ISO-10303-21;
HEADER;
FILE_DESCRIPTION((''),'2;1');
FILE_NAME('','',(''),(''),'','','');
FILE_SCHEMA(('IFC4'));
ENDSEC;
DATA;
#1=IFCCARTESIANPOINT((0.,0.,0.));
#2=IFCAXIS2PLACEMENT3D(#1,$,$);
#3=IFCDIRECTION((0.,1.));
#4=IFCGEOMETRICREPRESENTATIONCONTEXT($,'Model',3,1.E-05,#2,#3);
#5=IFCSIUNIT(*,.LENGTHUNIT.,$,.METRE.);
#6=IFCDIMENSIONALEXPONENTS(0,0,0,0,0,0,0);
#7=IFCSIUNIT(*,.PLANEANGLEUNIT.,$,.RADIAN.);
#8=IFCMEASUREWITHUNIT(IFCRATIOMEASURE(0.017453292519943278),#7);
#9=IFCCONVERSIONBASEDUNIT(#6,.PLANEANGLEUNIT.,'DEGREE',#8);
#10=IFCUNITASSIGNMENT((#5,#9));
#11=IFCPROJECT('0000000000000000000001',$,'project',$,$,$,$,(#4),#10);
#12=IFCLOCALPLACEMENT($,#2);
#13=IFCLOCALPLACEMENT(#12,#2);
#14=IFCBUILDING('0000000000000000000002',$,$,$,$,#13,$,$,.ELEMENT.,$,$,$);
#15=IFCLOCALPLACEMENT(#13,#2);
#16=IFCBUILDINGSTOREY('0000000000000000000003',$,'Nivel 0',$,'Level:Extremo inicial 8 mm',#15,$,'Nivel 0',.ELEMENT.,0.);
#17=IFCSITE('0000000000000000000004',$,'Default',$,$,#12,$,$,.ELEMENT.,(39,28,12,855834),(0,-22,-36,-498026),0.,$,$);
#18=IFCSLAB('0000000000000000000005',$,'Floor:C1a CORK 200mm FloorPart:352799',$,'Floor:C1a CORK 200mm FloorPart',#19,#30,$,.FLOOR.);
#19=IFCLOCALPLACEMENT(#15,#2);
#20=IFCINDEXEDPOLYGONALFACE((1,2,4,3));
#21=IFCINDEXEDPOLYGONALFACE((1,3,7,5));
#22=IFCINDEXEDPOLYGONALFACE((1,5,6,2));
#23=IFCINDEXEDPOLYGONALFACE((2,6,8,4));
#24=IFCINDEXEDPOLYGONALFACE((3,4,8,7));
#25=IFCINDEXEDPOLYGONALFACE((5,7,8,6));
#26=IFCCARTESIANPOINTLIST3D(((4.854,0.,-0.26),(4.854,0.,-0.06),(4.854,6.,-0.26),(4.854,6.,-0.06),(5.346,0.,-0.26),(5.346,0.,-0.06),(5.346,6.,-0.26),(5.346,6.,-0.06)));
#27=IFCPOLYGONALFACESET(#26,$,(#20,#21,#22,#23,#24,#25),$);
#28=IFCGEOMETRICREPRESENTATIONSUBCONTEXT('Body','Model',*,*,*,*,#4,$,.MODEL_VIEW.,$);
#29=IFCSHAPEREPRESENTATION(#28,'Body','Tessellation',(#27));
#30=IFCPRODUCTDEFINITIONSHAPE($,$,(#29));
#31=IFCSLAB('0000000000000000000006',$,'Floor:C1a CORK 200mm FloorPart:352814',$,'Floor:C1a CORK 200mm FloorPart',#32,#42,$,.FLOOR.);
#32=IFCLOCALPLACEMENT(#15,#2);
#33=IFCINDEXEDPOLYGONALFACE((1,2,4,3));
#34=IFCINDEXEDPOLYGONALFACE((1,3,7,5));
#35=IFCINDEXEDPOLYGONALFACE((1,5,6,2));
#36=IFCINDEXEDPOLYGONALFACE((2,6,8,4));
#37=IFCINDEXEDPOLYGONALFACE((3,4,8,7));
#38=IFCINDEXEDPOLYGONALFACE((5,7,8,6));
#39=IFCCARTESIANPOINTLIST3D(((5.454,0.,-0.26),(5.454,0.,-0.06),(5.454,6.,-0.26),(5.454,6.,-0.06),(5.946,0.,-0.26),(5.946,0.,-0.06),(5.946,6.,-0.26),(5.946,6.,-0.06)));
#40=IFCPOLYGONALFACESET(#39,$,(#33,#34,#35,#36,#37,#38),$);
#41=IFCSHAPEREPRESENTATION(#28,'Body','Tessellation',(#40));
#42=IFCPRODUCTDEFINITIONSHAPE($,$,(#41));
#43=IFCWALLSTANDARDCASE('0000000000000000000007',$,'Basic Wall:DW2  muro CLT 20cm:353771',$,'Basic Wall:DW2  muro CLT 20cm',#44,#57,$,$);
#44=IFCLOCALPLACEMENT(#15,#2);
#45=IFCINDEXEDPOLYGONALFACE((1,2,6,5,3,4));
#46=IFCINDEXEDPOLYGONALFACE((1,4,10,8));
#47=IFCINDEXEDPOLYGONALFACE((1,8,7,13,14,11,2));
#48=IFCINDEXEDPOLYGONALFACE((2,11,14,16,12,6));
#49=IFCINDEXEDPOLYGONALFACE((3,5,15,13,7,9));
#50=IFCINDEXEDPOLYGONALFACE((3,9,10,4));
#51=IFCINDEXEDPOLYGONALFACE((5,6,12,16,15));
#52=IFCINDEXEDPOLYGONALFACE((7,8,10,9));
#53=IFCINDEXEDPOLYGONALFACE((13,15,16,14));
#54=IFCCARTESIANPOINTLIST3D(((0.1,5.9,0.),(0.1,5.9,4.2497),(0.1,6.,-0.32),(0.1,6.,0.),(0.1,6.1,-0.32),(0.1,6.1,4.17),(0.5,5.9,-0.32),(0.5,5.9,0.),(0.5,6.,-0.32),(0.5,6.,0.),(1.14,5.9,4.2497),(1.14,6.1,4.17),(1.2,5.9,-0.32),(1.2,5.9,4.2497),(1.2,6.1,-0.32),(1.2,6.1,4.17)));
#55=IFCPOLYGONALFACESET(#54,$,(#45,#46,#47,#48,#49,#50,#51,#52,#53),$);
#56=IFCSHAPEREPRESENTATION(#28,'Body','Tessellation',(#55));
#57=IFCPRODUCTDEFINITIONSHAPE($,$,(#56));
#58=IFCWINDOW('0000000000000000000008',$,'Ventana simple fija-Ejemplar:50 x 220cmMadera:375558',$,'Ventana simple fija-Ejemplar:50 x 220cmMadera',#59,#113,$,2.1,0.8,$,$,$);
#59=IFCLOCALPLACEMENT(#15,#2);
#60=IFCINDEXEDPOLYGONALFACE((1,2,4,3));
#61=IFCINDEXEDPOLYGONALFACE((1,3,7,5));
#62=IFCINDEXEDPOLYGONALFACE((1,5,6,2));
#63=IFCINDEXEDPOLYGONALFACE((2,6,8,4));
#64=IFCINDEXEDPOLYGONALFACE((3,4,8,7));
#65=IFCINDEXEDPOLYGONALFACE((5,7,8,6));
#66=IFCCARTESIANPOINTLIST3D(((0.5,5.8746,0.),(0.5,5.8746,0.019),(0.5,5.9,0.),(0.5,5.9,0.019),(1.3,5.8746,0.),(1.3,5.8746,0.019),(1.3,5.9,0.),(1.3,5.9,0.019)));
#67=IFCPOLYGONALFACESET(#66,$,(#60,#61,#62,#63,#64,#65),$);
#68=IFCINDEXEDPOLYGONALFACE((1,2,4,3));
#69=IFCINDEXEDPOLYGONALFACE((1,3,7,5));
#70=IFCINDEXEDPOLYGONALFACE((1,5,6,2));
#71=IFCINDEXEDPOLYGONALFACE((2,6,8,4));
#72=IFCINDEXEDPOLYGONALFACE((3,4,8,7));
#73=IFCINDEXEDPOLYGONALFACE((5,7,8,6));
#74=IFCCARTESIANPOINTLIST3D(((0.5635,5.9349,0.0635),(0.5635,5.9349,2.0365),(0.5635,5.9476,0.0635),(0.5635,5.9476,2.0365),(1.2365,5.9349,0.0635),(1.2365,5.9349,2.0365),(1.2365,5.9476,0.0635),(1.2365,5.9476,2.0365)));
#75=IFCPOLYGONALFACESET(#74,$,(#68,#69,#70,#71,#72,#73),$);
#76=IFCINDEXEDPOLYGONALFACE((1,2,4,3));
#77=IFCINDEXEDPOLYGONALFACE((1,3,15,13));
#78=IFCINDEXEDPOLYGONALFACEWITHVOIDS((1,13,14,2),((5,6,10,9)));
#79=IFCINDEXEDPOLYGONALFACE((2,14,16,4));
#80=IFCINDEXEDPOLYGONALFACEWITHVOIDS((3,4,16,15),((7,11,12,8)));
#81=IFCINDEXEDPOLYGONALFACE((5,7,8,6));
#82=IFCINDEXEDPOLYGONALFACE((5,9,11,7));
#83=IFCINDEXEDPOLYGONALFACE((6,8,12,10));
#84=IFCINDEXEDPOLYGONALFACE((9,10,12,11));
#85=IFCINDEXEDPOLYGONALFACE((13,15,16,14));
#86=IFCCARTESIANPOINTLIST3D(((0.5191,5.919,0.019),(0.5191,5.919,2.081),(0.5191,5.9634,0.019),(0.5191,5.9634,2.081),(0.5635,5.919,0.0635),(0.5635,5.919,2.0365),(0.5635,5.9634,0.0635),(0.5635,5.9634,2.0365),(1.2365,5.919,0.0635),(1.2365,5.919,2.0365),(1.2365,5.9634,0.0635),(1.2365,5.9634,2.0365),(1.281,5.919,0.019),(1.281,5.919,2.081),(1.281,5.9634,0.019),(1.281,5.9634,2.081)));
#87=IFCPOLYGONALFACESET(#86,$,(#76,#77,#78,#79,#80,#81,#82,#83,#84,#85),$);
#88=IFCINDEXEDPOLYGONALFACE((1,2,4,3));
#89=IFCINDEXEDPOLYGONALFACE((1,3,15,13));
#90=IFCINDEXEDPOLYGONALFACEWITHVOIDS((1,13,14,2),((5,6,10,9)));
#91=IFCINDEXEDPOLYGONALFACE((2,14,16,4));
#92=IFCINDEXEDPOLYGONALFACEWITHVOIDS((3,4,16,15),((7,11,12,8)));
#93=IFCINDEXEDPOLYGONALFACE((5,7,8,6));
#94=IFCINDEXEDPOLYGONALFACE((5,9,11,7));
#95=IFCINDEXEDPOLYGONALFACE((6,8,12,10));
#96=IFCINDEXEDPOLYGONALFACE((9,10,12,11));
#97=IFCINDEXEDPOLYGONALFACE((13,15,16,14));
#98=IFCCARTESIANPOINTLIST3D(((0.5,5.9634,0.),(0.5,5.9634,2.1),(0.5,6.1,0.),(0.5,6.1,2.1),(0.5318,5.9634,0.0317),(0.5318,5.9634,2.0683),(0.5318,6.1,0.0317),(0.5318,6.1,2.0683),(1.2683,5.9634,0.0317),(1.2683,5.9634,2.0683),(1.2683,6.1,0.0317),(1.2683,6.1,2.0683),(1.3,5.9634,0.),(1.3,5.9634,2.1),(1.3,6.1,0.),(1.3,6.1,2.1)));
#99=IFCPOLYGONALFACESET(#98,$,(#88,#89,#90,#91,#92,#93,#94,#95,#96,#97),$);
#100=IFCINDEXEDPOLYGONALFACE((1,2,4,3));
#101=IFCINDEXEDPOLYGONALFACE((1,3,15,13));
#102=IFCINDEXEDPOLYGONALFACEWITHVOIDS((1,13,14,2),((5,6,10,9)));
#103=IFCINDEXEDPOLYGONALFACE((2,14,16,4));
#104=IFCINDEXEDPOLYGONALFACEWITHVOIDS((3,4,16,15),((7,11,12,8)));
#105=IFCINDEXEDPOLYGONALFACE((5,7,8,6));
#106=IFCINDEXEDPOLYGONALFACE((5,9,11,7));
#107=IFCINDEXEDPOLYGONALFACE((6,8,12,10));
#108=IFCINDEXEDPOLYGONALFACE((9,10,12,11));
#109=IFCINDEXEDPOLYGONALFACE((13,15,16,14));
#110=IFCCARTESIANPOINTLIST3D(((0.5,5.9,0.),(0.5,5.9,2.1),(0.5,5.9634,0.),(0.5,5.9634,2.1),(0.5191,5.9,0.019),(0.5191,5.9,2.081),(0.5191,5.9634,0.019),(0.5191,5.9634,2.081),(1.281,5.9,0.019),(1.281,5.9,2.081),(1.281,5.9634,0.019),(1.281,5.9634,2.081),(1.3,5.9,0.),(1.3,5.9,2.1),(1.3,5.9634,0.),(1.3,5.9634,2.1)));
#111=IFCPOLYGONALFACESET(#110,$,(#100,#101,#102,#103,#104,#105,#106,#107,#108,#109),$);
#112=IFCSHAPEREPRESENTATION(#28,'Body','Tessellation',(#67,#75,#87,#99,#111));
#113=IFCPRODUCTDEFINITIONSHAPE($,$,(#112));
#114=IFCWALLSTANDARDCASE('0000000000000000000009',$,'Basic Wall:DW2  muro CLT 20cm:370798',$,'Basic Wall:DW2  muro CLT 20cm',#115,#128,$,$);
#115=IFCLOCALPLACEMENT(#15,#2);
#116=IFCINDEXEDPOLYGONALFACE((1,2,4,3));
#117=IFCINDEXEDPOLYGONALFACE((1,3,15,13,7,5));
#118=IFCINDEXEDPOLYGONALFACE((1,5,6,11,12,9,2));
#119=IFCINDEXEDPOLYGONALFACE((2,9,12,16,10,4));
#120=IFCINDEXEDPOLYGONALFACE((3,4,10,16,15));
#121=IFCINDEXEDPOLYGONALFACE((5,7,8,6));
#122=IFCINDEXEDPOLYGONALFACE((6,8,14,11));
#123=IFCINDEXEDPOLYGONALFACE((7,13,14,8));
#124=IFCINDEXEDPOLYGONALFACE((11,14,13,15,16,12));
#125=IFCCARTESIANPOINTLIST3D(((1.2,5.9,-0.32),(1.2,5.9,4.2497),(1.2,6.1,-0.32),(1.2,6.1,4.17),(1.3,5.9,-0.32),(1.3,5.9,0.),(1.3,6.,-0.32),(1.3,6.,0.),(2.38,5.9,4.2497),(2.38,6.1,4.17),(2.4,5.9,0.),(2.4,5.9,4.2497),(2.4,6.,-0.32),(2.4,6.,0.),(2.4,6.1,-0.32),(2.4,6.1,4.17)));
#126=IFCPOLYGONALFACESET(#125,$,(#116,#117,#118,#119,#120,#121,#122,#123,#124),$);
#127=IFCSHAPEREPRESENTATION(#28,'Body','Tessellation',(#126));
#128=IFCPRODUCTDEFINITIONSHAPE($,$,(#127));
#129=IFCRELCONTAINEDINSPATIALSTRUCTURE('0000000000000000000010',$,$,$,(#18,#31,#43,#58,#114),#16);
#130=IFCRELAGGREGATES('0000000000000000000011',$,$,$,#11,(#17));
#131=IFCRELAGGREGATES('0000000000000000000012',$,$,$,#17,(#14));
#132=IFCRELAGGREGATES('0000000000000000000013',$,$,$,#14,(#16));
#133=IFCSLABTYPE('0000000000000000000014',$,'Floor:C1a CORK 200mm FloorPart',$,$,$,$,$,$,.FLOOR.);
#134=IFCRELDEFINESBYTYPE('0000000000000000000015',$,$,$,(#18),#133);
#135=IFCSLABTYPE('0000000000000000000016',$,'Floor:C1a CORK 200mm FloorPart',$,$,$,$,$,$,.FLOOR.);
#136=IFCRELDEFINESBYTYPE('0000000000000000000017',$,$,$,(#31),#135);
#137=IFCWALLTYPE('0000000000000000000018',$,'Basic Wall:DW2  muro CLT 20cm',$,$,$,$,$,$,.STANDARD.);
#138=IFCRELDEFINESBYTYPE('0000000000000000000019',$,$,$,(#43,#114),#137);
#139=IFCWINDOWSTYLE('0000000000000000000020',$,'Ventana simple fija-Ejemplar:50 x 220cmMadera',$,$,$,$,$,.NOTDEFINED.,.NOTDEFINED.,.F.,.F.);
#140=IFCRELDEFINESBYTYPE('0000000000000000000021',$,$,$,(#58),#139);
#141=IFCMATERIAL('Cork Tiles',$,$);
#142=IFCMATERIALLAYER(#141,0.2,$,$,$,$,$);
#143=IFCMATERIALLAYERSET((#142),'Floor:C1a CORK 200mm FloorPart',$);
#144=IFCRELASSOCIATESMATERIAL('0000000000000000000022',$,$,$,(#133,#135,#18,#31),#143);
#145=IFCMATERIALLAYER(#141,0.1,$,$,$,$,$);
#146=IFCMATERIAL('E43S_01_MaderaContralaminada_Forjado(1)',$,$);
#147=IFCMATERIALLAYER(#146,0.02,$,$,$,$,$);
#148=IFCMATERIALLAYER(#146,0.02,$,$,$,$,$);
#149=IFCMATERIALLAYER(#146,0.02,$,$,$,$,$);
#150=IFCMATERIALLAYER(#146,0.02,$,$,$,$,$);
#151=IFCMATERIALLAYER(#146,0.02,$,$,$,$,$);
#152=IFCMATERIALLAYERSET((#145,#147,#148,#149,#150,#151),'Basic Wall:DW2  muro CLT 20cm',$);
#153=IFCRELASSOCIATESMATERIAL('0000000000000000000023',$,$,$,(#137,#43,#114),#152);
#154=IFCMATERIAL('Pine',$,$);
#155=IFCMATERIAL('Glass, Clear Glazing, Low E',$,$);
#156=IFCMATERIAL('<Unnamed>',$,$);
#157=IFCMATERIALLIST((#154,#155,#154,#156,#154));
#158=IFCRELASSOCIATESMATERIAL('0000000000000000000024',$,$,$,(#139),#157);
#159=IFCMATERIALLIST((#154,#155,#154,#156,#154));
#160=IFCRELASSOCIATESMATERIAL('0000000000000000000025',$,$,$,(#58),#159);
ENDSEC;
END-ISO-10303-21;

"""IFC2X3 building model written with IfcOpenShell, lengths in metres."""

from ifc_helpers import new_model, entity, si_unit, converted_unit, direction, frame, frame_2d, origin, origin_2d_with_axis, place, context, subcontext, project, spatial, polyline, rectangle, outline, extrude, clip, bounded_halfspace, source, transform, mapped, material, material_list, layer, layer_set, layer_usage, type_object, type_shapes, element, fill, save


model = new_model("IFC2X3")

# Units and contexts
model_context = context("Model", 3, precision=1e-05, world=origin(), true_north=direction((0.0, 1.0)))
body_context = subcontext(model_context, "Body", "Model", "MODEL_VIEW")
ifc_project = project(units=[si_unit("LENGTHUNIT", "METRE"), converted_unit("PLANEANGLEUNIT", "DEGREE", entity("IfcRatioMeasure", 0.017453292519943278), si_unit("PLANEANGLEUNIT", "RADIAN"), dimensions=[0, 0, 0, 0, 0, 0, 0])], contexts=[model_context])

# Site, building, storey
site_placement = place(None, origin())
site = spatial("IfcSite", under=ifc_project, at=site_placement, Name="Default", CompositionType="ELEMENT", RefLatitude=(39, 28, 12, 855834), RefLongitude=(0, -22, -36, -498026), RefElevation=0.0)
building_placement = place(site_placement, origin())
building = spatial("IfcBuilding", under=site, at=building_placement, CompositionType="ELEMENT")
storey_placement = place(building_placement, origin())
storey = spatial("IfcBuildingStorey", under=building, at=storey_placement, Name="Nivel 0", ObjectType="Level:Extremo inicial 8 mm", LongName="Nivel 0", CompositionType="ELEMENT", Elevation=0.0)

# Shared definitions
ifc_material_1 = material(Name="E43S_01_MaderaContralaminada_Forjado(1)")

# Slabs
ifc_material_2 = material(Name="Cork Tiles")
ifc_layer_1 = layer(ifc_material_2, 0.2)
ifc_layer_set_1 = layer_set([ifc_layer_1], Name="Floor:C1a CORK 200mm FloorPart")
ifc_layer_usage_1 = layer_usage(ifc_layer_set_1, "AXIS3", "POSITIVE", 0.0)
slab_type_1 = type_object("IfcSlabType", Name="Floor:C1a CORK 200mm FloorPart", PredefinedType="FLOOR", material=ifc_layer_set_1)
slab_1_placement = place(storey_placement, origin())
element("IfcSlab", 1, at=slab_1_placement, inside=storey, type_object=slab_type_1, material=ifc_layer_usage_1, Name="Floor:C1a CORK 200mm FloorPart:352799", ObjectType="Floor:C1a CORK 200mm FloorPart", PredefinedType="FLOOR", context=body_context, shape_type="SweptSolid", body=[
    extrude(rectangle(XDim=6.0, YDim=0.492, at=frame_2d((0.0, 0.0), x_axis=(1.0, 0.0))), frame((5.1, 3.0, -0.06), z_axis=(0.0, 0.0, -1.0), x_axis=(0.0, 1.0, 0.0)), (0.0, 0.0, 1.0), 0.2),
])
ifc_layer_usage_2 = layer_usage(ifc_layer_set_1, "AXIS3", "POSITIVE", 0.0)
slab_type_2 = type_object("IfcSlabType", Name="Floor:C1a CORK 200mm FloorPart", PredefinedType="FLOOR", material=ifc_layer_set_1)
slab_2_placement = place(storey_placement, origin())
element("IfcSlab", 2, at=slab_2_placement, inside=storey, type_object=slab_type_2, material=ifc_layer_usage_2, Name="Floor:C1a CORK 200mm FloorPart:352814", ObjectType="Floor:C1a CORK 200mm FloorPart", PredefinedType="FLOOR", context=body_context, shape_type="SweptSolid", body=[
    extrude(rectangle(XDim=6.0, YDim=0.492, at=frame_2d((0.0, 0.0), x_axis=(1.0, 0.0))), frame((5.7, 3.0, -0.06), z_axis=(0.0, 0.0, -1.0), x_axis=(0.0, 1.0, 0.0)), (0.0, 0.0, 1.0), 0.2),
])

# Wall, openings, window
ifc_layer_2 = layer(ifc_material_2, 0.1)
ifc_layer_3 = layer(ifc_material_1, 0.02)
ifc_layer_4 = layer(ifc_material_1, 0.02)
ifc_layer_5 = layer(ifc_material_1, 0.02)
ifc_layer_6 = layer(ifc_material_1, 0.02)
ifc_layer_7 = layer(ifc_material_1, 0.02)
ifc_layer_set_2 = layer_set([ifc_layer_2, ifc_layer_3, ifc_layer_4, ifc_layer_5, ifc_layer_6, ifc_layer_7], Name="Basic Wall:DW2  muro CLT 20cm")
ifc_layer_usage_3 = layer_usage(ifc_layer_set_2, "AXIS2", "NEGATIVE", 0.1)
wall_type_1 = type_object("IfcWallType", Name="Basic Wall:DW2  muro CLT 20cm", PredefinedType="STANDARD", material=ifc_layer_set_2)
wall_1_placement = place(storey_placement, frame((0.1, 6.0, -0.32)))
wall_1 = element("IfcWallStandardCase", 3, at=wall_1_placement, inside=storey, type_object=wall_type_1, material=ifc_layer_usage_3, Name="Basic Wall:DW2  muro CLT 20cm:353771", ObjectType="Basic Wall:DW2  muro CLT 20cm", context=body_context, shape_type="Clipping", body=[
    clip(clip(clip(extrude(rectangle(XDim=1.1, YDim=0.2, at=frame_2d((0.55, 0.0), x_axis=(-1.0, 0.0))), origin(), (0.0, 0.0, 1.0), 4.5697), bounded_halfspace(frame((0.0, -0.1, 4.5697), z_axis=(0.0, 0.370288, 0.928917), x_axis=(-1.0, 0.0, 0.0)), False, frame((0.0, -0.1, 4.5697)), polyline([(0.0, 0.0), (1.04, 0.0), (1.04, 0.2), (0.0, 0.2), (0.0, 0.0)]))), bounded_halfspace(frame((1.04, -0.1, 4.5697), z_axis=(0.0, 0.370288, 0.928917), x_axis=(-1.0, 0.0, 0.0)), False, frame((1.04, -0.1, 4.5697)), polyline([(0.0, 0.0), (0.06, 0.0), (0.06, 0.2), (0.0, 0.2), (0.0, 0.0)]))), bounded_halfspace(frame((0.0, -0.1, 0.32), z_axis=(0.0, 0.0, -1.0), x_axis=(0.0, 1.0, 0.0)), False, frame((0.0, -0.1, 0.32)), polyline([(0.0, 0.0), (0.4, 0.0), (0.4, 0.1), (0.0, 0.1), (0.0, 0.0)]))),
])
opening_1_placement = place(wall_1_placement, origin())
element("IfcOpeningElement", 4, at=opening_1_placement, cuts=wall_1, ObjectType="Recess", context=body_context, shape_type="SweptSolid", body=[
    extrude(rectangle(XDim=0.32, YDim=1.1, at=frame_2d((0.0, 0.0), x_axis=(0.0, 1.0))), frame((0.55, -0.1, 2.66), z_axis=(0.0, 1.0, 0.0), x_axis=(1.0, 0.0, 0.0)), (0.0, 0.0, 1.0), 0.1),
    extrude(rectangle(XDim=0.32, YDim=1.2, at=frame_2d((0.0, 0.0), x_axis=(0.0, 1.0))), frame((1.7, -0.1, 2.66), z_axis=(0.0, 1.0, 0.0), x_axis=(1.0, 0.0, 0.0)), (0.0, 0.0, 1.0), 0.1),
    extrude(rectangle(XDim=0.32, YDim=1.2, at=frame_2d((0.0, 0.0), x_axis=(0.0, 1.0))), frame((2.9, -0.1, 2.66), z_axis=(0.0, 1.0, 0.0), x_axis=(1.0, 0.0, 0.0)), (0.0, 0.0, 1.0), 0.1),
])
opening_2_placement = place(wall_1_placement, frame((1.2, 0.1, 0.32)))
opening_2 = element("IfcOpeningElement", 5, at=opening_2_placement, cuts=wall_1, ObjectType="Opening", context=body_context, shape_type="SweptSolid", body=[
    extrude(rectangle(XDim=2.1, YDim=0.8, at=frame_2d((1.05, 0.4), x_axis=(-1.0, 0.0))), frame((0.0, 0.0, 0.0), z_axis=(0.0, -1.0, 0.0), x_axis=(0.0, 0.0, 1.0)), (0.0, 0.0, 1.0), 0.2),
])
ifc_material_3 = material(Name="Pine")
ifc_material_4 = material(Name="Glass, Clear Glazing, Low E")
ifc_material_5 = material(Name="<Unnamed>")
ifc_material_list_1 = material_list([ifc_material_3, ifc_material_4, ifc_material_3, ifc_material_5, ifc_material_3])
ifc_material_list_2 = material_list([ifc_material_3, ifc_material_4, ifc_material_3, ifc_material_5, ifc_material_3])
window_style = type_object("IfcWindowStyle", Name="Ventana simple fija-Ejemplar:50 x 220cmMadera", ConstructionType="NOTDEFINED", OperationType="NOTDEFINED", ParameterTakesPrecedence=False, Sizeable=False, material=ifc_material_list_2)
shared_shape_1 = source(origin(), body_context, "Body", "SweptSolid", [
    extrude(rectangle(XDim=0.8, YDim=0.0254, at=origin_2d_with_axis()), frame((0.4762, 0.2127, 0.0), z_axis=(0.0, 0.0, 1.0), x_axis=(-1.0, 0.0, 0.0)), (0.0, 0.0, 1.0), 0.019),
    extrude(rectangle(XDim=0.673, YDim=0.0127, at=frame_2d((0.0, 0.0), x_axis=(1.0, 0.0))), frame((0.4762, 0.1588, 0.0635)), (0.0, 0.0, 1.0), 1.973),
    extrude(outline(polyline([(-0.3809, -1.031), (0.3809, -1.031), (0.3809, 1.031), (-0.3809, 1.031), (-0.3809, -1.031)]), holes=[polyline([(-0.3365, -0.9865), (-0.3365, 0.9865), (0.3365, 0.9865), (0.3365, -0.9865), (-0.3365, -0.9865)])]), frame((0.4762, 0.181, 1.05), z_axis=(0.0, -1.0, 0.0), x_axis=(-1.0, 0.0, 0.0)), (0.0, 0.0, 1.0), 0.0444),
    extrude(outline(polyline([(-0.4, -1.05), (0.4, -1.05), (0.4, 1.05), (-0.4, 1.05), (-0.4, -1.05)]), holes=[polyline([(-0.3683, -1.0183), (-0.3683, 1.0183), (0.3682, 1.0183), (0.3682, -1.0183), (-0.3683, -1.0183)])]), frame((0.4762, 0.1365, 1.05), z_axis=(0.0, -1.0, 0.0), x_axis=(-1.0, 0.0, 0.0)), (0.0, 0.0, 1.0), 0.1365),
    extrude(outline(polyline([(-1.05, -0.4), (1.05, -0.4), (1.05, 0.4), (-1.05, 0.4), (-1.05, -0.4)]), holes=[polyline([(-1.031, -0.3809), (-1.031, 0.381), (1.031, 0.381), (1.031, -0.3809), (-1.031, -0.3809)])]), frame((0.4762, 0.2, 1.05), z_axis=(0.0, -1.0, 0.0), x_axis=(0.0, 0.0, -1.0)), (0.0, 0.0, 1.0), 0.0635),
])
type_shapes(window_style, [shared_shape_1])
window_placement = place(opening_2_placement, frame((0.0762, 0.0, 0.0), z_axis=(0.0, 0.0, 1.0), x_axis=(-1.0, 0.0, 0.0)))
window = element("IfcWindow", 6, at=window_placement, inside=storey, type_object=window_style, material=ifc_material_list_1, Name="Ventana simple fija-Ejemplar:50 x 220cmMadera:375558", ObjectType="Ventana simple fija-Ejemplar:50 x 220cmMadera", OverallHeight=2.1, OverallWidth=0.8, context=body_context, shape_type="MappedRepresentation", body=[
    mapped(shared_shape_1, transform((0.0, 0.0, 0.0), scale=1.0)),
])
fill(opening_2, window)

# Wall, openings
ifc_layer_usage_4 = layer_usage(ifc_layer_set_2, "AXIS2", "NEGATIVE", 0.1)
wall_2_placement = place(storey_placement, frame((1.2, 6.0, -0.32)))
wall_2 = element("IfcWallStandardCase", 7, at=wall_2_placement, inside=storey, type_object=wall_type_1, material=ifc_layer_usage_4, Name="Basic Wall:DW2  muro CLT 20cm:370798", ObjectType="Basic Wall:DW2  muro CLT 20cm", context=body_context, shape_type="Clipping", body=[
    clip(clip(clip(extrude(rectangle(XDim=1.2, YDim=0.2, at=frame_2d((0.6, 0.0), x_axis=(-1.0, 0.0))), origin(), (0.0, 0.0, 1.0), 4.5697), bounded_halfspace(frame((0.0, -0.1, 4.5697), z_axis=(0.0, 0.370288, 0.928917), x_axis=(-1.0, 0.0, 0.0)), False, frame((0.0, -0.1, 4.5697)), polyline([(0.0, 0.0), (1.18, 0.0), (1.18, 0.2), (0.0, 0.2), (0.0, 0.0)]))), bounded_halfspace(frame((1.18, -0.1, 4.5697), z_axis=(0.0, 0.370288, 0.928917), x_axis=(-1.0, 0.0, 0.0)), False, frame((1.18, -0.1, 4.5697)), polyline([(0.0, 0.0), (0.02, 0.0), (0.02, 0.2), (0.0, 0.2), (0.0, 0.0)]))), bounded_halfspace(frame((1.2, 0.0, 0.32), z_axis=(0.0, 0.0, -1.0), x_axis=(0.0, 1.0, 0.0)), False, frame((1.2, 0.0, 0.32)), polyline([(0.0, 0.0), (-1.1, 0.0), (-1.1, -0.1), (0.0, -0.1), (0.0, 0.0)]))),
])
opening_3_placement = place(wall_2_placement, origin())
element("IfcOpeningElement", 8, at=opening_3_placement, cuts=wall_2, ObjectType="Opening", context=body_context, shape_type="SweptSolid", body=[
    extrude(rectangle(XDim=2.1, YDim=0.8, at=frame_2d((0.0, 0.0), x_axis=(1.0, 0.0))), frame((-0.3, -1.424, 1.37), z_axis=(0.0, 1.0, 0.0), x_axis=(0.0, 0.0, -1.0)), (0.0, 0.0, 1.0), 3.048),
])
opening_4_placement = place(wall_2_placement, origin())
element("IfcOpeningElement", 9, at=opening_4_placement, cuts=wall_2, ObjectType="Opening", context=body_context, shape_type="SweptSolid", body=[
    extrude(rectangle(XDim=1.53, YDim=0.9, at=frame_2d((0.0, 0.0), x_axis=(1.0, 0.0))), frame((4.05, -1.378, 3.585), z_axis=(0.0, 1.0, 0.0), x_axis=(0.0, 0.0, -1.0)), (0.0, 0.0, 1.0), 3.048),
])
opening_5_placement = place(wall_2_placement, origin())
element("IfcOpeningElement", 10, at=opening_5_placement, cuts=wall_2, ObjectType="Recess", context=body_context, shape_type="SweptSolid", body=[
    extrude(rectangle(XDim=0.32, YDim=1.1, at=frame_2d((0.0, 0.0), x_axis=(0.0, 1.0))), frame((-0.55, -0.1, 2.66), z_axis=(0.0, 1.0, 0.0), x_axis=(1.0, 0.0, 0.0)), (0.0, 0.0, 1.0), 0.1),
    extrude(rectangle(XDim=0.32, YDim=1.2, at=frame_2d((0.0, 0.0), x_axis=(0.0, 1.0))), frame((0.6, -0.1, 2.66), z_axis=(0.0, 1.0, 0.0), x_axis=(1.0, 0.0, 0.0)), (0.0, 0.0, 1.0), 0.1),
    extrude(rectangle(XDim=0.32, YDim=1.2, at=frame_2d((0.0, 0.0), x_axis=(0.0, 1.0))), frame((1.8, -0.1, 2.66), z_axis=(0.0, 1.0, 0.0), x_axis=(1.0, 0.0, 0.0)), (0.0, 0.0, 1.0), 0.1),
])

save(model, "model.ifc")
